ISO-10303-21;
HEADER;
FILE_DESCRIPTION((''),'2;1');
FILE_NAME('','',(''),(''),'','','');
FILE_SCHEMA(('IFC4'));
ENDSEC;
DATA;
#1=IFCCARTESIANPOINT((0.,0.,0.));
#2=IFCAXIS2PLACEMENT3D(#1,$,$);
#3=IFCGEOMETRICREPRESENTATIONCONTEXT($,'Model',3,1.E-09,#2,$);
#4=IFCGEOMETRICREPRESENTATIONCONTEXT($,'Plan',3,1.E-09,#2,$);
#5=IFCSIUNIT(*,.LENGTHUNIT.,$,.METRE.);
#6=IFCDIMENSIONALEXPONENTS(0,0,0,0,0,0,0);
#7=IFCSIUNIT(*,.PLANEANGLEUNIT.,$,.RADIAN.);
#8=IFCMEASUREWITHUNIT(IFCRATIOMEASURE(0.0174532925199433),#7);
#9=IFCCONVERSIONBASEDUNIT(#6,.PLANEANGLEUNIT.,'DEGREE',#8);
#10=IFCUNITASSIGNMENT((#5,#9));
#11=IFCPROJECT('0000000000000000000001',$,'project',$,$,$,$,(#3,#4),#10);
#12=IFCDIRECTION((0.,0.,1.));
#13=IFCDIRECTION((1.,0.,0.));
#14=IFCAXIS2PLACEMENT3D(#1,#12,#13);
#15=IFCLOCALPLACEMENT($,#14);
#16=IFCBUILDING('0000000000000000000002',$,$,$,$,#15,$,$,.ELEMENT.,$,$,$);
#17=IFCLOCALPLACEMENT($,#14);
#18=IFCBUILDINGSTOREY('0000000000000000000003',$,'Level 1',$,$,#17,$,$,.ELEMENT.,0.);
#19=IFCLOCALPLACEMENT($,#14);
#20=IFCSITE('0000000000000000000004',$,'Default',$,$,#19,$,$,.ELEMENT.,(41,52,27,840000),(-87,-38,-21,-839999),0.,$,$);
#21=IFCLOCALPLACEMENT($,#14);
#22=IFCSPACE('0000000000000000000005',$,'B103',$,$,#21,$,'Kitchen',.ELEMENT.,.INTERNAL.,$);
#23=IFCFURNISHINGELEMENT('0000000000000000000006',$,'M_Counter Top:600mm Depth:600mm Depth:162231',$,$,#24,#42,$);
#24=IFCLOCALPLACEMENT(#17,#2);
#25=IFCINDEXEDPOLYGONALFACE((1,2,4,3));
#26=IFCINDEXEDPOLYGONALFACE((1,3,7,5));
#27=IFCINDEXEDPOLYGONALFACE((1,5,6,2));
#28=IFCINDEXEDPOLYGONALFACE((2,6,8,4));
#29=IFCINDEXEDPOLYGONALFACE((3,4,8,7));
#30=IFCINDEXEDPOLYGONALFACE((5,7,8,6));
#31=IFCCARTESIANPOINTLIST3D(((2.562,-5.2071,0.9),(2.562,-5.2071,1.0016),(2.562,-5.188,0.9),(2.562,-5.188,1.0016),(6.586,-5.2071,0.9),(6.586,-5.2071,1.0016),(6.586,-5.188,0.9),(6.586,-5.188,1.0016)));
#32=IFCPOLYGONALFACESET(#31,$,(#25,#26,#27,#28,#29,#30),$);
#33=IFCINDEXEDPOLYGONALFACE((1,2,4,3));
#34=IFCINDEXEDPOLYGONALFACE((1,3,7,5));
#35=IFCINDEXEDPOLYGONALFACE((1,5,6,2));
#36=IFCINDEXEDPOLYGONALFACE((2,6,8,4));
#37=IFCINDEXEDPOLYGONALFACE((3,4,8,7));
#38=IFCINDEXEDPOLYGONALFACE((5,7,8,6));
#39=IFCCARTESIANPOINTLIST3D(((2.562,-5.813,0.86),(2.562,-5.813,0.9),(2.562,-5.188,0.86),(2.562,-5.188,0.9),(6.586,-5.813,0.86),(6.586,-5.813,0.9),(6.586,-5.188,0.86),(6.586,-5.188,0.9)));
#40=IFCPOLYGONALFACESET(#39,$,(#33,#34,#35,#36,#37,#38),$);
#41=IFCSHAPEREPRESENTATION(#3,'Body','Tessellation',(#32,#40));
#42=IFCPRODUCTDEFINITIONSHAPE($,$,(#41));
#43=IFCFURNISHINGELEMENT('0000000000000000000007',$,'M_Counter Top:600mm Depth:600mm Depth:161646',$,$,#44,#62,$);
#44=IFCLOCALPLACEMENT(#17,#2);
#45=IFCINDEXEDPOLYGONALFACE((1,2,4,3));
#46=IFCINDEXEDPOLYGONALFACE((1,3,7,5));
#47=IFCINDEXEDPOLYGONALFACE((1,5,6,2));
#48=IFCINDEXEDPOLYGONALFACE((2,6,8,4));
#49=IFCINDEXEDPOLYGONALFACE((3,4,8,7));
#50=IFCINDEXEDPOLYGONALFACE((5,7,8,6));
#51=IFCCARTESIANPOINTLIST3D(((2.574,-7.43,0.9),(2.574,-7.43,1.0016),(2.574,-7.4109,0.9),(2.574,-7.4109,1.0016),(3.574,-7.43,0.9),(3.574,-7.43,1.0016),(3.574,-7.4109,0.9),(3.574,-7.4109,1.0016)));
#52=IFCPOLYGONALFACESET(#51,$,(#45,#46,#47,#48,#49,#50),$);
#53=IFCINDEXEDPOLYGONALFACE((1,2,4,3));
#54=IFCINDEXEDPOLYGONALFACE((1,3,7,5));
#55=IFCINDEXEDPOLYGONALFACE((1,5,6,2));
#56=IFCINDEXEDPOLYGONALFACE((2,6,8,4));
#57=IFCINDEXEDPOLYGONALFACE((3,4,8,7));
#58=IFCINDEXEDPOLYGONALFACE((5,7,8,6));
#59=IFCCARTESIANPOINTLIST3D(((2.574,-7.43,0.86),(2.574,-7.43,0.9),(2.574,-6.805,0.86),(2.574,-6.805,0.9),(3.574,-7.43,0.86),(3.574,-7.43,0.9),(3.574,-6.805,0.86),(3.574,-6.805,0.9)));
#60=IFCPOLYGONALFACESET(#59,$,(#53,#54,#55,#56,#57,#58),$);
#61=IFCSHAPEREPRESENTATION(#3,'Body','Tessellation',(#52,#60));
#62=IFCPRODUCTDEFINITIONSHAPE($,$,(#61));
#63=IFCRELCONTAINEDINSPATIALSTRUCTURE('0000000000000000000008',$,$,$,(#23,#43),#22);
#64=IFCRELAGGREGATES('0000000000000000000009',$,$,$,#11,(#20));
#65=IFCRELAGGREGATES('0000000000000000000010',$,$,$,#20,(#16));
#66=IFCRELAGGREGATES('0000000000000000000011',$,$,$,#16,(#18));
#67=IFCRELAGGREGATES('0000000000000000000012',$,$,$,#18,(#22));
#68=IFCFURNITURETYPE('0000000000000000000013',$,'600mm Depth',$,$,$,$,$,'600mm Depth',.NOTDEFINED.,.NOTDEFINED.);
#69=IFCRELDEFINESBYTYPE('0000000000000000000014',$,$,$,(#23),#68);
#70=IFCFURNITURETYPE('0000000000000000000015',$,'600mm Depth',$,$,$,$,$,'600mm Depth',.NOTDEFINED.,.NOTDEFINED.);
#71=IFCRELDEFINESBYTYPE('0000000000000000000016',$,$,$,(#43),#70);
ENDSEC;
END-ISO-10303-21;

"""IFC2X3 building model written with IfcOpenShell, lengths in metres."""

from ifc_helpers import new_model, entity, si_unit, converted_unit, frame, origin, origin_with_axes, origin_2d_with_axis, place, context, project, spatial, rectangle, extrude, source, transform, mapped, type_object, type_shapes, element, save


model = new_model("IFC2X3")

# Units and contexts
model_context = context("Model", 3, precision=1e-09, world=origin())
plan_context = context("Plan", 3, precision=1e-09, world=origin())
ifc_project = project(units=[si_unit("LENGTHUNIT", "METRE"), converted_unit("PLANEANGLEUNIT", "DEGREE", entity("IfcRatioMeasure", 0.0174532925199433), si_unit("PLANEANGLEUNIT", "RADIAN"), dimensions=[0, 0, 0, 0, 0, 0, 0])], contexts=[model_context, plan_context])

# Site, building, storey, space
site_placement = place(None, origin_with_axes())
site = spatial("IfcSite", under=ifc_project, at=site_placement, Name="Default", CompositionType="ELEMENT", RefLatitude=(41, 52, 27, 840000), RefLongitude=(-87, -38, -21, -839999), RefElevation=0.0)
building_placement = place(None, origin_with_axes())
building = spatial("IfcBuilding", under=site, at=building_placement, CompositionType="ELEMENT")
storey_placement = place(None, origin_with_axes())
storey = spatial("IfcBuildingStorey", under=building, at=storey_placement, Name="Level 1", CompositionType="ELEMENT", Elevation=0.0)
space_placement = place(None, origin_with_axes())
space = spatial("IfcSpace", under=storey, at=space_placement, Name="B103", LongName="Kitchen", CompositionType="ELEMENT", InteriorOrExteriorSpace="INTERNAL")

# Furnishing elements
furniture_type_1 = type_object("IfcFurnitureType", Name="600mm Depth", ElementType="600mm Depth", AssemblyPlace="NOTDEFINED")
shared_shape_1 = source(origin(), model_context, "Body", "SweptSolid", [
    extrude(rectangle(XDim=0.0191, YDim=4.024, at=origin_2d_with_axis()), frame((0.8115, -0.0095, 0.9), z_axis=(0.0, 0.0, 1.0), x_axis=(0.0, -1.0, 0.0)), (0.0, 0.0, 1.0), 0.1016),
    extrude(rectangle(XDim=4.024, YDim=0.625, at=origin_2d_with_axis()), frame((0.8115, -0.3125, 0.86), z_axis=(0.0, 0.0, 1.0), x_axis=(-1.0, 0.0, 0.0)), (0.0, 0.0, 1.0), 0.04),
])
type_shapes(furniture_type_1, [shared_shape_1])
furnishing_1_placement = place(None, frame((3.7625, -5.188, 0.0), z_axis=(0.0, 0.0, 1.0), x_axis=(1.0, 0.0, 0.0)))
element("IfcFurnishingElement", 1, at=furnishing_1_placement, inside=space, type_object=furniture_type_1, Name="M_Counter Top:600mm Depth:600mm Depth:162231", context=model_context, shape_type="MappedRepresentation", body=[
    mapped(shared_shape_1, transform((0.0, 0.0, 0.0), scale=1.0)),
])
furniture_type_2 = type_object("IfcFurnitureType", Name="600mm Depth", ElementType="600mm Depth", AssemblyPlace="NOTDEFINED")
shared_shape_2 = source(origin(), model_context, "Body", "SweptSolid", [
    extrude(rectangle(XDim=0.0191, YDim=1.0, at=origin_2d_with_axis()), frame((-0.7005, -0.0095, 0.9), z_axis=(0.0, 0.0, 1.0), x_axis=(0.0, -1.0, 0.0)), (0.0, 0.0, 1.0), 0.1016),
    extrude(rectangle(XDim=1.0, YDim=0.625, at=origin_2d_with_axis()), frame((-0.7005, -0.3125, 0.86), z_axis=(0.0, 0.0, 1.0), x_axis=(-1.0, 0.0, 0.0)), (0.0, 0.0, 1.0), 0.04),
])
type_shapes(furniture_type_2, [shared_shape_2])
furnishing_2_placement = place(None, frame((2.3735, -7.43, 0.0), z_axis=(0.0, 0.0, 1.0), x_axis=(-1.0, 0.0, 0.0)))
element("IfcFurnishingElement", 2, at=furnishing_2_placement, inside=space, type_object=furniture_type_2, Name="M_Counter Top:600mm Depth:600mm Depth:161646", context=model_context, shape_type="MappedRepresentation", body=[
    mapped(shared_shape_2, transform((0.0, 0.0, 0.0), scale=1.0)),
])

save(model, "model.ifc")
